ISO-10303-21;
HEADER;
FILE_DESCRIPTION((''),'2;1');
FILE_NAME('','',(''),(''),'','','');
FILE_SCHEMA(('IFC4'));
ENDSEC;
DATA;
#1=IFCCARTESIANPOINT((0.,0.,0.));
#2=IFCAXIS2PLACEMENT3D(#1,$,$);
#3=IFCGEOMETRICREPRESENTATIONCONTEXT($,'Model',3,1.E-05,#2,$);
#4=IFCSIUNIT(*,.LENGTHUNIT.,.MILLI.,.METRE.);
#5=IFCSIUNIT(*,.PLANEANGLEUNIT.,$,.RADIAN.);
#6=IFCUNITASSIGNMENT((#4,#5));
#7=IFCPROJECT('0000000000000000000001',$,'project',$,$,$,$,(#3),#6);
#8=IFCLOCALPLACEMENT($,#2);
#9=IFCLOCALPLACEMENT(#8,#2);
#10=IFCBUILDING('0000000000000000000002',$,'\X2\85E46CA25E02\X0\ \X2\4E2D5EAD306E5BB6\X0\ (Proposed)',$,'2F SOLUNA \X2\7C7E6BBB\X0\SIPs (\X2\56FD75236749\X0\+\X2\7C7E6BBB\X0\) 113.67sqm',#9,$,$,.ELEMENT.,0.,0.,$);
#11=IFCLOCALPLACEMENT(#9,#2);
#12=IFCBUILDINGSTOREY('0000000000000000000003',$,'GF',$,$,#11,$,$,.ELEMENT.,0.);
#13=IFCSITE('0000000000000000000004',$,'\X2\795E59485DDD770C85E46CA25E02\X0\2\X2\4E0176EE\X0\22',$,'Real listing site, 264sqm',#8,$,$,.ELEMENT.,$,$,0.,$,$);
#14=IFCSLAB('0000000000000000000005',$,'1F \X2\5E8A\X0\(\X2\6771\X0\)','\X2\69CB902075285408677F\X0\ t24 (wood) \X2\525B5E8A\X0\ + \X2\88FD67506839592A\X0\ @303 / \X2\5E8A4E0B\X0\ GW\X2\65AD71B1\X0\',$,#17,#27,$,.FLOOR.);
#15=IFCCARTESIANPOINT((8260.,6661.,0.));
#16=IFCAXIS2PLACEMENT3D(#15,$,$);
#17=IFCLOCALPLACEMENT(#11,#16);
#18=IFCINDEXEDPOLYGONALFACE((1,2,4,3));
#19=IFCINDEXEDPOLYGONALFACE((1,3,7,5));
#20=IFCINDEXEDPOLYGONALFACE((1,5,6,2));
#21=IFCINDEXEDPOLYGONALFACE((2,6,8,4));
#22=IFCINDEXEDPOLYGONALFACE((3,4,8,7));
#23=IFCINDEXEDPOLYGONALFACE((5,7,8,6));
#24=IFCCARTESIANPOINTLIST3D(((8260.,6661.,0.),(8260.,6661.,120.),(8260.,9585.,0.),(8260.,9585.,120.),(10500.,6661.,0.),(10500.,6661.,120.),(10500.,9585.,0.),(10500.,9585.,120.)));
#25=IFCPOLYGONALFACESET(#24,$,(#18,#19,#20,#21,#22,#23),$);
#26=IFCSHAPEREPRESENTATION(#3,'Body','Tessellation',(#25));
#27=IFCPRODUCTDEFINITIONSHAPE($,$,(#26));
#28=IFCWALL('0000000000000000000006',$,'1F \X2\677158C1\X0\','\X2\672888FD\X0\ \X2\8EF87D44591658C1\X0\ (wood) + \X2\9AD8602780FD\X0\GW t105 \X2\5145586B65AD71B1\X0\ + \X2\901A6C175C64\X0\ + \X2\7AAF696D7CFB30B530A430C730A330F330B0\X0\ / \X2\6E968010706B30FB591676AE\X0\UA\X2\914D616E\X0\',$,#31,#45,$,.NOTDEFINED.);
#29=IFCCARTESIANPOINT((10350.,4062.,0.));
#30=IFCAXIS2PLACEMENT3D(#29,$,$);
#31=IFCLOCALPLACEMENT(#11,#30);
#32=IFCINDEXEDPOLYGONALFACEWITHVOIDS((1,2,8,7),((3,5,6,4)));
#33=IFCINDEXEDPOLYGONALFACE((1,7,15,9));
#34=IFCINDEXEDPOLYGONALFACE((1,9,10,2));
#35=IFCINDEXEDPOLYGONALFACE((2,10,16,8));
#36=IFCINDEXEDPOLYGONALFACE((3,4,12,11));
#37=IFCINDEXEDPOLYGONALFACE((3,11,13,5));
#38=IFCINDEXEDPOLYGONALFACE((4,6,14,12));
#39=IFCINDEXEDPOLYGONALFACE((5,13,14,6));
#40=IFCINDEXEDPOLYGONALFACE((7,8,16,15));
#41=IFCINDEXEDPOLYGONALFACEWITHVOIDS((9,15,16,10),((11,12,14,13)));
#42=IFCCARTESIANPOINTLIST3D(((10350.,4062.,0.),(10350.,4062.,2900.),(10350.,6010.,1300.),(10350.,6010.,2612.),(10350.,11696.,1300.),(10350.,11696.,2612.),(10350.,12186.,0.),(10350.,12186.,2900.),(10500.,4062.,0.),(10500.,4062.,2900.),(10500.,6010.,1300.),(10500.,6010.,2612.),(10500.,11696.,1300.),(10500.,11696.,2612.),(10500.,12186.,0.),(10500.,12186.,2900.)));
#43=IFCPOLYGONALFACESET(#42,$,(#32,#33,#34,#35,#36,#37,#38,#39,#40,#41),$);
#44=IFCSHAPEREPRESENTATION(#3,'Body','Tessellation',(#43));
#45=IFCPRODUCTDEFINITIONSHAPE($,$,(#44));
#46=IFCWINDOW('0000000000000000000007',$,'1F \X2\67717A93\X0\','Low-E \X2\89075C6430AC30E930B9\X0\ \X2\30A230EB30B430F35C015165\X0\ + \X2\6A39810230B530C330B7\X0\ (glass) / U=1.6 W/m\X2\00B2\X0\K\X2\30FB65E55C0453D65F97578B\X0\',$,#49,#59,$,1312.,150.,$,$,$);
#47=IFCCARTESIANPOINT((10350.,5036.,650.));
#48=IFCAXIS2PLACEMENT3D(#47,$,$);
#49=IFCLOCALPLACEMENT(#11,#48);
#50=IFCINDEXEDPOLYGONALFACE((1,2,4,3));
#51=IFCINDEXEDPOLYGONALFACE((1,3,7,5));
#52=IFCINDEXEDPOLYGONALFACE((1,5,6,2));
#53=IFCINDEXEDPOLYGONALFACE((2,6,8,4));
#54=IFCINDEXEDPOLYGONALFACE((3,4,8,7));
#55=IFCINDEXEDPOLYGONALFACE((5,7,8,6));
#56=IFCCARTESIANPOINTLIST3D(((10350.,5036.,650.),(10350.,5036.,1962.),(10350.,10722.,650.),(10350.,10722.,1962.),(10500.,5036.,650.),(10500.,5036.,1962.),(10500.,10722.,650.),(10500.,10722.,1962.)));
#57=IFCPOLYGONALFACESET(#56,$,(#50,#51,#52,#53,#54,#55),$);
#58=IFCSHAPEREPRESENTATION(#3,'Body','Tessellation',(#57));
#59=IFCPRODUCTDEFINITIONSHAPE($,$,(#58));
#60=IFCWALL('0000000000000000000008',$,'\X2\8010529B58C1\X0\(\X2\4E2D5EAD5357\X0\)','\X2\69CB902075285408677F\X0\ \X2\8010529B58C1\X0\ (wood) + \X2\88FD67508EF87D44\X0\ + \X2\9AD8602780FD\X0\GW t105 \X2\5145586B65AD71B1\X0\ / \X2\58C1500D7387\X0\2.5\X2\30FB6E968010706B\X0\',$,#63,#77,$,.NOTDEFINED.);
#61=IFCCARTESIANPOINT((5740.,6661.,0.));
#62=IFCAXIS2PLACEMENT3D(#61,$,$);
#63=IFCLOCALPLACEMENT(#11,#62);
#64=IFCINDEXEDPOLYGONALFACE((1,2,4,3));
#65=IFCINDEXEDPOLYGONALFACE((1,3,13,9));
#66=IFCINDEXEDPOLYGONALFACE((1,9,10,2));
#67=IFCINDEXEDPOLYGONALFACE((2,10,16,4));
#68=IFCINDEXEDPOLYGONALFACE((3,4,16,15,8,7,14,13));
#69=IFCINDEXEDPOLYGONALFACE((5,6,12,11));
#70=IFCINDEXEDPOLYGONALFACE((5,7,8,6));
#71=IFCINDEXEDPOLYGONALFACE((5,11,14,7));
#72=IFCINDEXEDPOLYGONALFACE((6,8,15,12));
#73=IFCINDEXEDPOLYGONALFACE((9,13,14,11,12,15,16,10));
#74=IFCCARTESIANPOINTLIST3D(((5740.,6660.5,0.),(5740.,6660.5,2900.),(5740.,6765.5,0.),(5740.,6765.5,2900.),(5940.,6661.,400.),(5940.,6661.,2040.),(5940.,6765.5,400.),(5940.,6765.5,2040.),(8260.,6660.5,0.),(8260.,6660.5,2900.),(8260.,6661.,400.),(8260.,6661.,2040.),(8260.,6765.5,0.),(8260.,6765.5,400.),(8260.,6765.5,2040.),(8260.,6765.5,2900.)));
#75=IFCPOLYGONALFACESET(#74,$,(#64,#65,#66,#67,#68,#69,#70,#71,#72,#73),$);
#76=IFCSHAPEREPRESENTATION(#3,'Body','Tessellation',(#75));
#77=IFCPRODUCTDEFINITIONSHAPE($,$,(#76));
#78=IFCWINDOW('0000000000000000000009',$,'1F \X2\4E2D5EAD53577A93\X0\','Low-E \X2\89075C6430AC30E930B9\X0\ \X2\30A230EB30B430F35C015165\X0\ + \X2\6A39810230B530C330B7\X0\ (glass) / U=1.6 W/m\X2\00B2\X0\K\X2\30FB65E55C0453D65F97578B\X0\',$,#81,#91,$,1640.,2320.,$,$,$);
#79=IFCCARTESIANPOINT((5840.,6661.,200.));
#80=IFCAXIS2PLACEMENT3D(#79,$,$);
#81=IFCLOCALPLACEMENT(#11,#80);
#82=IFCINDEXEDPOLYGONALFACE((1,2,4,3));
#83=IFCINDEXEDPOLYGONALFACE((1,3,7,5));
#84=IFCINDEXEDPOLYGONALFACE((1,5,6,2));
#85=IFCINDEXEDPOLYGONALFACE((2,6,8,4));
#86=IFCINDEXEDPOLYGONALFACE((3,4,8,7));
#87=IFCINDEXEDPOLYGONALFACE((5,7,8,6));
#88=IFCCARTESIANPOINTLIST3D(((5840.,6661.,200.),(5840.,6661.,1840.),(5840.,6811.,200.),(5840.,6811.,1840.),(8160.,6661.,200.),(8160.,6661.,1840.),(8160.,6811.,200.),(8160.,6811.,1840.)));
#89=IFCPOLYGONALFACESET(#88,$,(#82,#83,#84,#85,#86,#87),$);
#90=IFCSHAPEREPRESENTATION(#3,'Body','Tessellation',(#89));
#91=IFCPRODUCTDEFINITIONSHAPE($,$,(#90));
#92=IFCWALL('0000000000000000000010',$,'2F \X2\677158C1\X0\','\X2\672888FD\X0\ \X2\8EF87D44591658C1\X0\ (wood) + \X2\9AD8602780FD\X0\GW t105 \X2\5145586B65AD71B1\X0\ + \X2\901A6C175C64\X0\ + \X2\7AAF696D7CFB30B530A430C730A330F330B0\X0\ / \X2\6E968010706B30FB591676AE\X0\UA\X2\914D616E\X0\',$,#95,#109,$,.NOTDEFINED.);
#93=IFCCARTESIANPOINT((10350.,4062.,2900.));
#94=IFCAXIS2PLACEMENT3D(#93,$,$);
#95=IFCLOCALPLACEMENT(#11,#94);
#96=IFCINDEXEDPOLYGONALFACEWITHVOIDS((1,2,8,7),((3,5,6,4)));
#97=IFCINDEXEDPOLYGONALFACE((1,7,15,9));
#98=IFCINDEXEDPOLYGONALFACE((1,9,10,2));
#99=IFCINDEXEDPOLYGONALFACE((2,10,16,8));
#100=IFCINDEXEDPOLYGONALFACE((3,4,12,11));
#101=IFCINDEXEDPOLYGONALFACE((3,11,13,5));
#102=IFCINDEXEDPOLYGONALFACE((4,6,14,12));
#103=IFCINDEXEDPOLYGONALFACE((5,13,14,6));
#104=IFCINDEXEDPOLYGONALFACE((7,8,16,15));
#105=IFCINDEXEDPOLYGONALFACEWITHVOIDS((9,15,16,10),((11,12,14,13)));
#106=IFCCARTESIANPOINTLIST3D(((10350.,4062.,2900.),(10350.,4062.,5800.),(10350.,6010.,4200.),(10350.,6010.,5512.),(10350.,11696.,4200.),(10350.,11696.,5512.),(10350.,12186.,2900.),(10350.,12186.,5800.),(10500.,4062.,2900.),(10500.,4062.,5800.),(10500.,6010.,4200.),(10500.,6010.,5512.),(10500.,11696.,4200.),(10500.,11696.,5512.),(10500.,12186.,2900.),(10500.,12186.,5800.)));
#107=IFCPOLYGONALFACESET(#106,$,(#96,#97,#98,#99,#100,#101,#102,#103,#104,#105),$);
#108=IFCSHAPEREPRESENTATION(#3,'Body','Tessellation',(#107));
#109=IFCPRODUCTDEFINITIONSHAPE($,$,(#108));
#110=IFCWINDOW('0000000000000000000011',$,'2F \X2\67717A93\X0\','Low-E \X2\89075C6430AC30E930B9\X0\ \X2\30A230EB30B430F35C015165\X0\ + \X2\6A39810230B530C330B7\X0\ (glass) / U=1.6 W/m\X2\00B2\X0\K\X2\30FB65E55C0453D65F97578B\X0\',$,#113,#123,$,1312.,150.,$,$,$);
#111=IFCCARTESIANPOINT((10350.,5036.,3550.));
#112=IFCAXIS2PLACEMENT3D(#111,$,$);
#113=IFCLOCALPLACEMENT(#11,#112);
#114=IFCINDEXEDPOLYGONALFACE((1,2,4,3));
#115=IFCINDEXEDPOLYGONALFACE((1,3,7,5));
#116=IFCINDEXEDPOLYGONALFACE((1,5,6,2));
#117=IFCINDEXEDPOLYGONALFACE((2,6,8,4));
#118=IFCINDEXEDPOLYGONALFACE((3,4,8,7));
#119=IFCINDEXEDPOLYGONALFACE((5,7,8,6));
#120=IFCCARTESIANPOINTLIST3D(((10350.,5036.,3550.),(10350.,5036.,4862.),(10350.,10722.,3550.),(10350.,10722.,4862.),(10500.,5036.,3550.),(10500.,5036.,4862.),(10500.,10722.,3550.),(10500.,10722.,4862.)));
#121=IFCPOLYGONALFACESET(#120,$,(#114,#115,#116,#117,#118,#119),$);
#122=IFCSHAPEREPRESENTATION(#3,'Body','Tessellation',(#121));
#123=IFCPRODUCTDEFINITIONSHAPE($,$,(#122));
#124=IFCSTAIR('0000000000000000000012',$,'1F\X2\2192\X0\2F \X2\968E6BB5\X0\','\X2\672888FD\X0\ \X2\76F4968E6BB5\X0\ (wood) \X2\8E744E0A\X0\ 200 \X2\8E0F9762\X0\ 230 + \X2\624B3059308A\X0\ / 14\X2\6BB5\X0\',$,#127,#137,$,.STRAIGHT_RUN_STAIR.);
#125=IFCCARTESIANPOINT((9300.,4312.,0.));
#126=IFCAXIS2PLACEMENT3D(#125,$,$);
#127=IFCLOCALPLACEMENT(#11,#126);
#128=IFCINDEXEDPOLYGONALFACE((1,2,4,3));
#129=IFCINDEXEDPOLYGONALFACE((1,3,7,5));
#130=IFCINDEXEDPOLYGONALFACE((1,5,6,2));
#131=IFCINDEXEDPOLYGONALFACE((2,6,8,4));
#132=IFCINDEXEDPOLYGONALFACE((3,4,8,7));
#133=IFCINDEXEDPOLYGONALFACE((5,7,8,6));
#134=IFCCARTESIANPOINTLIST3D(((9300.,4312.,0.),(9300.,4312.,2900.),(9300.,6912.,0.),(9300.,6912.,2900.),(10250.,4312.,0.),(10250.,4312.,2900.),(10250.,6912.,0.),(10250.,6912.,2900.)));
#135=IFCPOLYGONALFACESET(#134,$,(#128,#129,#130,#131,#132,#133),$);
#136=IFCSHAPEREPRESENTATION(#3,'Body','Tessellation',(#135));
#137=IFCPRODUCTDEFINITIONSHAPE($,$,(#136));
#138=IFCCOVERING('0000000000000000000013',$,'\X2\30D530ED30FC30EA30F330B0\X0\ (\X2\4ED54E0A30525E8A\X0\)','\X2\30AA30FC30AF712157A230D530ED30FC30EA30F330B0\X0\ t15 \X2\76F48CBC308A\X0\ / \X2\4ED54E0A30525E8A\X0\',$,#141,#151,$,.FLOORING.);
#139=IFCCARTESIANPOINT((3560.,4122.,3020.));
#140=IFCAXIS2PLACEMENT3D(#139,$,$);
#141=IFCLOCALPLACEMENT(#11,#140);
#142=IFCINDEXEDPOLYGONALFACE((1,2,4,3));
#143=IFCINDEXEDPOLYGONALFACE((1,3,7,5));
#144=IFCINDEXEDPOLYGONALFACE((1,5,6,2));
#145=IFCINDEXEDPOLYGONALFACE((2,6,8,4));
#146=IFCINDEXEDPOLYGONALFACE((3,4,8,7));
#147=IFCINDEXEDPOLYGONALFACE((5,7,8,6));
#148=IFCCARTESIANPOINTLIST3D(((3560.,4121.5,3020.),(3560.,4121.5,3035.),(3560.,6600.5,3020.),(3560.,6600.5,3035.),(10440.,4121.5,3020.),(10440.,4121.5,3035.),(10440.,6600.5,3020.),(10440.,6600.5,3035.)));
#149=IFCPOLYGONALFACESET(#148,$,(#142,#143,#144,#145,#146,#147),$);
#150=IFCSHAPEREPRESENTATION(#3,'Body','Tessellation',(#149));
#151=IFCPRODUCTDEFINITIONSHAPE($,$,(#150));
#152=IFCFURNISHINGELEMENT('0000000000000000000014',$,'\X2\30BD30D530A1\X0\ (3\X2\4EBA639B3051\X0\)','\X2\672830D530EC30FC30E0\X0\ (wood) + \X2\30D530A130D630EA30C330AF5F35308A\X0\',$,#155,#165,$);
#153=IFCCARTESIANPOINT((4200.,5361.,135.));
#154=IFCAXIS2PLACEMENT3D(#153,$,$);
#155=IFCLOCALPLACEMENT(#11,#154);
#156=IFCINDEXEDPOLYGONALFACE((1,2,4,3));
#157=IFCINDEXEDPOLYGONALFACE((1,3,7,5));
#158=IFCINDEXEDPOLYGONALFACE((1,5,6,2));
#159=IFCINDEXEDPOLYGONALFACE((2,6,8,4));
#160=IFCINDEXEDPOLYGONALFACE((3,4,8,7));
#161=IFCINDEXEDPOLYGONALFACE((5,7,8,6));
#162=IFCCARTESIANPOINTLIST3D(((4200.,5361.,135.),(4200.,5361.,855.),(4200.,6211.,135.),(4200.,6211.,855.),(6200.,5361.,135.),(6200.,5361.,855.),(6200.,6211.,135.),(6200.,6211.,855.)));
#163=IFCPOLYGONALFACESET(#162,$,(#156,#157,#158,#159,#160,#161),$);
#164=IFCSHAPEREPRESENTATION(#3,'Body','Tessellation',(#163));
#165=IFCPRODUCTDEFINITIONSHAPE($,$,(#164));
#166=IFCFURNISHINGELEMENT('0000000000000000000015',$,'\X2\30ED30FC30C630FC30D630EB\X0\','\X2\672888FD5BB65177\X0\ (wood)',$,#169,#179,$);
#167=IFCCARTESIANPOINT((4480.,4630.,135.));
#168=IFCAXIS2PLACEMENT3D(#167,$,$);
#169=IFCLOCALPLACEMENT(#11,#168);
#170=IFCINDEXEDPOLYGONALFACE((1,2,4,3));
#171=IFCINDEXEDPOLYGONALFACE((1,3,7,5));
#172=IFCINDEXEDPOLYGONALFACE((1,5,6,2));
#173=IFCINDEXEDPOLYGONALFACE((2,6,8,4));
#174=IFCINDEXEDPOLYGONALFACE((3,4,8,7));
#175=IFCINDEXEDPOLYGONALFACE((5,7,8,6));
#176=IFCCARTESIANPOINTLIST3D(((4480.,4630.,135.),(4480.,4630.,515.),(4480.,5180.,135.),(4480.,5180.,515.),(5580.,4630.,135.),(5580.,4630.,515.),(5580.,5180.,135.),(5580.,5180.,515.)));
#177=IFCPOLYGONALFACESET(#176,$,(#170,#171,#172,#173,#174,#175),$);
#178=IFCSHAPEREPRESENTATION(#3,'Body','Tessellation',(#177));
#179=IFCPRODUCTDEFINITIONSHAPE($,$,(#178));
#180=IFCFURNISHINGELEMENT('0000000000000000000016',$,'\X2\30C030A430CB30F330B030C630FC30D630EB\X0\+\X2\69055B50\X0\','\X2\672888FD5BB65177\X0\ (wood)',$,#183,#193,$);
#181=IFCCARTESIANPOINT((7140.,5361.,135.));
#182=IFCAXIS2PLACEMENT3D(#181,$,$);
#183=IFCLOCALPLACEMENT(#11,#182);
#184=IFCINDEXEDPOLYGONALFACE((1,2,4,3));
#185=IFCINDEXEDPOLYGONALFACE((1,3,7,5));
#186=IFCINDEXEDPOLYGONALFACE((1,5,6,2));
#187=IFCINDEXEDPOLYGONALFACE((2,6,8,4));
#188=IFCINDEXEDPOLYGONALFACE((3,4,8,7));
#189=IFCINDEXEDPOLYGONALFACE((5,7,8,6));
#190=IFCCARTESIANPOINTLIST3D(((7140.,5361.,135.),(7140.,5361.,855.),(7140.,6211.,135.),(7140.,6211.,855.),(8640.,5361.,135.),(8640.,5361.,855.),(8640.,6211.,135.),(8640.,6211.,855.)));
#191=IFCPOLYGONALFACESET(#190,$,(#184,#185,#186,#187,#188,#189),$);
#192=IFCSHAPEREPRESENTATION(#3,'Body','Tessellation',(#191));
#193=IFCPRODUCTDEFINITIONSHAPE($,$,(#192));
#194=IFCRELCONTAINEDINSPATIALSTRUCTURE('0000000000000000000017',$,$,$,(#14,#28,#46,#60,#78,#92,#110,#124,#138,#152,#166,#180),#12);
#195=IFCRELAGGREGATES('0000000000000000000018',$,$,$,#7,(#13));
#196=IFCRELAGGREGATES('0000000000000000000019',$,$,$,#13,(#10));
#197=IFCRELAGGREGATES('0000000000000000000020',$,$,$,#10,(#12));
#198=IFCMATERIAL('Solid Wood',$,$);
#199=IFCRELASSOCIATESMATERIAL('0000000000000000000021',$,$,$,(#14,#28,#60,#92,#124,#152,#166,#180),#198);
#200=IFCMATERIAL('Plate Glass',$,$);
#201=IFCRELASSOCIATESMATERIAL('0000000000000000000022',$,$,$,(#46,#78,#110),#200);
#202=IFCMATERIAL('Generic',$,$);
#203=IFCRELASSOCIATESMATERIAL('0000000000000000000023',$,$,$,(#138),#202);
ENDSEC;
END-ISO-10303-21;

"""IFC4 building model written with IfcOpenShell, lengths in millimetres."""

from ifc_helpers import new_model, si_unit, frame, frame_2d, origin, place, context, project, spatial, rectangle, extrude, material, element, fill, save


model = new_model("IFC4")

# Units and contexts
model_context = context("Model", 3, precision=1e-05, world=origin())
ifc_project = project(units=[si_unit("LENGTHUNIT", "METRE", prefix="MILLI"), si_unit("PLANEANGLEUNIT", "RADIAN")], contexts=[model_context])

# Site, building, storey
site_placement = place(None, origin())
site = spatial("IfcSite", under=ifc_project, at=site_placement, Name="神奈川県藤沢市2丁目22", ObjectType="Real listing site, 264sqm", CompositionType="ELEMENT", RefElevation=0.0)
building_placement = place(site_placement, origin())
building = spatial("IfcBuilding", under=site, at=building_placement, Name="藤沢市 中庭の家 (Proposed)", ObjectType="2F SOLUNA 籾殻SIPs (国産杉+籾殻) 113.67sqm", CompositionType="ELEMENT", ElevationOfRefHeight=0.0, ElevationOfTerrain=0.0)
storey_placement = place(building_placement, origin())
storey = spatial("IfcBuildingStorey", under=building, at=storey_placement, Name="GF", CompositionType="ELEMENT", Elevation=0.0)

# Slab
ifc_material_1 = material(Name="Solid Wood")
slab_placement = place(storey_placement, frame((8260.0, 6661.0, 0.0)))
element("IfcSlab", 1, at=slab_placement, inside=storey, material=ifc_material_1, Name="1F 床(東)", Description="構造用合板 t24 (wood) 剛床 + 製材根太 @303 / 床下 GW断熱", PredefinedType="FLOOR", context=model_context, shape_type="SweptSolid", body=[
    extrude(rectangle(XDim=2240.0, YDim=2924.0, at=frame_2d((1120.0, 1462.0))), frame((8260.0, 6661.0, 0.0)), (0.0, 0.0, 1.0), 120.0),
])

# Walls, openings, windows
wall_1_placement = place(storey_placement, frame((10350.0, 4062.0, 0.0)))
wall_1 = element("IfcWall", 2, at=wall_1_placement, inside=storey, material=ifc_material_1, Name="1F 東壁", Description="木製 軸組外壁 (wood) + 高性能GW t105 充填断熱 + 通気層 + 窯業系サイディング / 準耐火・外皮UA配慮", PredefinedType="NOTDEFINED", context=model_context, shape_type="SweptSolid", body=[
    extrude(rectangle(XDim=150.0, YDim=8124.0, at=frame_2d((75.0, 4062.0))), frame((10350.0, 4062.0, 0.0)), (0.0, 0.0, 1.0), 2900.0),
])
opening_1_placement = place(storey_placement, frame((10350.0, 5036.0, 650.0)))
opening_1 = element("IfcOpeningElement", 3, at=opening_1_placement, cuts=wall_1, PredefinedType="NOTDEFINED", context=model_context, shape_type="SweptSolid", body=[
    extrude(rectangle(XDim=150.0, YDim=5686.0, at=frame_2d((75.0, 2843.0))), frame((10350.0, 5036.0, 650.0)), (0.0, 0.0, 1.0), 1312.0),
])
ifc_material_2 = material(Name="Plate Glass")
window_1_placement = place(storey_placement, frame((10350.0, 5036.0, 650.0)))
window_1 = element("IfcWindow", 4, at=window_1_placement, inside=storey, material=ifc_material_2, Name="1F 東窓", Description="Low-E 複層ガラス アルゴン封入 + 樹脂サッシ (glass) / U=1.6 W/m²K・日射取得型", OverallHeight=1312.0, OverallWidth=150.0, context=model_context, shape_type="SweptSolid", body=[
    extrude(rectangle(XDim=150.0, YDim=5686.0, at=frame_2d((75.0, 2843.0))), frame((10350.0, 5036.0, 650.0)), (0.0, 0.0, 1.0), 1312.0),
])
fill(opening_1, window_1)
wall_2_placement = place(storey_placement, frame((5740.0, 6661.0, 0.0)))
wall_2 = element("IfcWall", 5, at=wall_2_placement, inside=storey, material=ifc_material_1, Name="耐力壁(中庭南)", Description="構造用合板 耐力壁 (wood) + 製材軸組 + 高性能GW t105 充填断熱 / 壁倍率2.5・準耐火", PredefinedType="NOTDEFINED", context=model_context, shape_type="SweptSolid", body=[
    extrude(rectangle(XDim=2520.0, YDim=105.0, at=frame_2d((1260.0, 52.0))), frame((5740.0, 6661.0, 0.0)), (0.0, 0.0, 1.0), 2900.0),
])
opening_2_placement = place(storey_placement, frame((5840.0, 6661.0, 200.0)))
opening_2 = element("IfcOpeningElement", 6, at=opening_2_placement, cuts=wall_2, PredefinedType="NOTDEFINED", context=model_context, shape_type="SweptSolid", body=[
    extrude(rectangle(XDim=2320.0, YDim=150.0, at=frame_2d((1160.0, 75.0))), frame((5840.0, 6661.0, 200.0)), (0.0, 0.0, 1.0), 1640.0),
])
window_2_placement = place(storey_placement, frame((5840.0, 6661.0, 200.0)))
window_2 = element("IfcWindow", 7, at=window_2_placement, inside=storey, material=ifc_material_2, Name="1F 中庭南窓", Description="Low-E 複層ガラス アルゴン封入 + 樹脂サッシ (glass) / U=1.6 W/m²K・日射取得型", OverallHeight=1640.0, OverallWidth=2320.0, context=model_context, shape_type="SweptSolid", body=[
    extrude(rectangle(XDim=2320.0, YDim=150.0, at=frame_2d((1160.0, 75.0))), frame((5840.0, 6661.0, 200.0)), (0.0, 0.0, 1.0), 1640.0),
])
fill(opening_2, window_2)

# Wall, opening, window
wall_3_placement = place(storey_placement, frame((10350.0, 4062.0, 2900.0)))
wall_3 = element("IfcWall", 8, at=wall_3_placement, inside=storey, material=ifc_material_1, Name="2F 東壁", Description="木製 軸組外壁 (wood) + 高性能GW t105 充填断熱 + 通気層 + 窯業系サイディング / 準耐火・外皮UA配慮", PredefinedType="NOTDEFINED", context=model_context, shape_type="SweptSolid", body=[
    extrude(rectangle(XDim=150.0, YDim=8124.0, at=frame_2d((75.0, 4062.0))), frame((10350.0, 4062.0, 2900.0)), (0.0, 0.0, 1.0), 2900.0),
])
opening_3_placement = place(storey_placement, frame((10350.0, 5036.0, 3550.0)))
opening_3 = element("IfcOpeningElement", 9, at=opening_3_placement, cuts=wall_3, PredefinedType="NOTDEFINED", context=model_context, shape_type="SweptSolid", body=[
    extrude(rectangle(XDim=150.0, YDim=5686.0, at=frame_2d((75.0, 2843.0))), frame((10350.0, 5036.0, 3550.0)), (0.0, 0.0, 1.0), 1312.0),
])
window_3_placement = place(storey_placement, frame((10350.0, 5036.0, 3550.0)))
window_3 = element("IfcWindow", 10, at=window_3_placement, inside=storey, material=ifc_material_2, Name="2F 東窓", Description="Low-E 複層ガラス アルゴン封入 + 樹脂サッシ (glass) / U=1.6 W/m²K・日射取得型", OverallHeight=1312.0, OverallWidth=150.0, context=model_context, shape_type="SweptSolid", body=[
    extrude(rectangle(XDim=150.0, YDim=5686.0, at=frame_2d((75.0, 2843.0))), frame((10350.0, 5036.0, 3550.0)), (0.0, 0.0, 1.0), 1312.0),
])
fill(opening_3, window_3)

# Stair
stair_placement = place(storey_placement, frame((9300.0, 4312.0, 0.0)))
element("IfcStair", 11, at=stair_placement, inside=storey, material=ifc_material_1, Name="1F→2F 階段", Description="木製 直階段 (wood) 蹴上 200 踏面 230 + 手すり / 14段", PredefinedType="STRAIGHT_RUN_STAIR", context=model_context, shape_type="SweptSolid", body=[
    extrude(rectangle(XDim=950.0, YDim=2600.0, at=frame_2d((475.0, 1300.0))), frame((9300.0, 4312.0, 0.0)), (0.0, 0.0, 1.0), 2900.0),
])

# Covering
ifc_material_3 = material(Name="Generic")
covering_placement = place(storey_placement, frame((3560.0, 4122.0, 3020.0)))
element("IfcCovering", 12, at=covering_placement, inside=storey, material=ifc_material_3, Name="フローリング (仕上げ床)", Description="オーク無垢フローリング t15 直貼り / 仕上げ床", PredefinedType="FLOORING", context=model_context, shape_type="SweptSolid", body=[
    extrude(rectangle(XDim=6880.0, YDim=2479.0, at=frame_2d((3440.0, 1239.0))), frame((3560.0, 4122.0, 3020.0)), (0.0, 0.0, 1.0), 15.0),
])

# Furnishing elements
furnishing_1_placement = place(storey_placement, frame((4200.0, 5361.0, 135.0)))
element("IfcFurnishingElement", 13, at=furnishing_1_placement, inside=storey, material=ifc_material_1, Name="ソファ (3人掛け)", Description="木フレーム (wood) + ファブリック張り", context=model_context, shape_type="SweptSolid", body=[
    extrude(rectangle(XDim=2000.0, YDim=850.0, at=frame_2d((1000.0, 425.0))), frame((4200.0, 5361.0, 135.0)), (0.0, 0.0, 1.0), 720.0),
])
furnishing_2_placement = place(storey_placement, frame((4480.0, 4630.0, 135.0)))
element("IfcFurnishingElement", 14, at=furnishing_2_placement, inside=storey, material=ifc_material_1, Name="ローテーブル", Description="木製家具 (wood)", context=model_context, shape_type="SweptSolid", body=[
    extrude(rectangle(XDim=1100.0, YDim=550.0, at=frame_2d((550.0, 275.0))), frame((4480.0, 4630.0, 135.0)), (0.0, 0.0, 1.0), 380.0),
])
furnishing_3_placement = place(storey_placement, frame((7140.0, 5361.0, 135.0)))
element("IfcFurnishingElement", 15, at=furnishing_3_placement, inside=storey, material=ifc_material_1, Name="ダイニングテーブル+椅子", Description="木製家具 (wood)", context=model_context, shape_type="SweptSolid", body=[
    extrude(rectangle(XDim=1500.0, YDim=850.0, at=frame_2d((750.0, 425.0))), frame((7140.0, 5361.0, 135.0)), (0.0, 0.0, 1.0), 720.0),
])

save(model, "model.ifc")
